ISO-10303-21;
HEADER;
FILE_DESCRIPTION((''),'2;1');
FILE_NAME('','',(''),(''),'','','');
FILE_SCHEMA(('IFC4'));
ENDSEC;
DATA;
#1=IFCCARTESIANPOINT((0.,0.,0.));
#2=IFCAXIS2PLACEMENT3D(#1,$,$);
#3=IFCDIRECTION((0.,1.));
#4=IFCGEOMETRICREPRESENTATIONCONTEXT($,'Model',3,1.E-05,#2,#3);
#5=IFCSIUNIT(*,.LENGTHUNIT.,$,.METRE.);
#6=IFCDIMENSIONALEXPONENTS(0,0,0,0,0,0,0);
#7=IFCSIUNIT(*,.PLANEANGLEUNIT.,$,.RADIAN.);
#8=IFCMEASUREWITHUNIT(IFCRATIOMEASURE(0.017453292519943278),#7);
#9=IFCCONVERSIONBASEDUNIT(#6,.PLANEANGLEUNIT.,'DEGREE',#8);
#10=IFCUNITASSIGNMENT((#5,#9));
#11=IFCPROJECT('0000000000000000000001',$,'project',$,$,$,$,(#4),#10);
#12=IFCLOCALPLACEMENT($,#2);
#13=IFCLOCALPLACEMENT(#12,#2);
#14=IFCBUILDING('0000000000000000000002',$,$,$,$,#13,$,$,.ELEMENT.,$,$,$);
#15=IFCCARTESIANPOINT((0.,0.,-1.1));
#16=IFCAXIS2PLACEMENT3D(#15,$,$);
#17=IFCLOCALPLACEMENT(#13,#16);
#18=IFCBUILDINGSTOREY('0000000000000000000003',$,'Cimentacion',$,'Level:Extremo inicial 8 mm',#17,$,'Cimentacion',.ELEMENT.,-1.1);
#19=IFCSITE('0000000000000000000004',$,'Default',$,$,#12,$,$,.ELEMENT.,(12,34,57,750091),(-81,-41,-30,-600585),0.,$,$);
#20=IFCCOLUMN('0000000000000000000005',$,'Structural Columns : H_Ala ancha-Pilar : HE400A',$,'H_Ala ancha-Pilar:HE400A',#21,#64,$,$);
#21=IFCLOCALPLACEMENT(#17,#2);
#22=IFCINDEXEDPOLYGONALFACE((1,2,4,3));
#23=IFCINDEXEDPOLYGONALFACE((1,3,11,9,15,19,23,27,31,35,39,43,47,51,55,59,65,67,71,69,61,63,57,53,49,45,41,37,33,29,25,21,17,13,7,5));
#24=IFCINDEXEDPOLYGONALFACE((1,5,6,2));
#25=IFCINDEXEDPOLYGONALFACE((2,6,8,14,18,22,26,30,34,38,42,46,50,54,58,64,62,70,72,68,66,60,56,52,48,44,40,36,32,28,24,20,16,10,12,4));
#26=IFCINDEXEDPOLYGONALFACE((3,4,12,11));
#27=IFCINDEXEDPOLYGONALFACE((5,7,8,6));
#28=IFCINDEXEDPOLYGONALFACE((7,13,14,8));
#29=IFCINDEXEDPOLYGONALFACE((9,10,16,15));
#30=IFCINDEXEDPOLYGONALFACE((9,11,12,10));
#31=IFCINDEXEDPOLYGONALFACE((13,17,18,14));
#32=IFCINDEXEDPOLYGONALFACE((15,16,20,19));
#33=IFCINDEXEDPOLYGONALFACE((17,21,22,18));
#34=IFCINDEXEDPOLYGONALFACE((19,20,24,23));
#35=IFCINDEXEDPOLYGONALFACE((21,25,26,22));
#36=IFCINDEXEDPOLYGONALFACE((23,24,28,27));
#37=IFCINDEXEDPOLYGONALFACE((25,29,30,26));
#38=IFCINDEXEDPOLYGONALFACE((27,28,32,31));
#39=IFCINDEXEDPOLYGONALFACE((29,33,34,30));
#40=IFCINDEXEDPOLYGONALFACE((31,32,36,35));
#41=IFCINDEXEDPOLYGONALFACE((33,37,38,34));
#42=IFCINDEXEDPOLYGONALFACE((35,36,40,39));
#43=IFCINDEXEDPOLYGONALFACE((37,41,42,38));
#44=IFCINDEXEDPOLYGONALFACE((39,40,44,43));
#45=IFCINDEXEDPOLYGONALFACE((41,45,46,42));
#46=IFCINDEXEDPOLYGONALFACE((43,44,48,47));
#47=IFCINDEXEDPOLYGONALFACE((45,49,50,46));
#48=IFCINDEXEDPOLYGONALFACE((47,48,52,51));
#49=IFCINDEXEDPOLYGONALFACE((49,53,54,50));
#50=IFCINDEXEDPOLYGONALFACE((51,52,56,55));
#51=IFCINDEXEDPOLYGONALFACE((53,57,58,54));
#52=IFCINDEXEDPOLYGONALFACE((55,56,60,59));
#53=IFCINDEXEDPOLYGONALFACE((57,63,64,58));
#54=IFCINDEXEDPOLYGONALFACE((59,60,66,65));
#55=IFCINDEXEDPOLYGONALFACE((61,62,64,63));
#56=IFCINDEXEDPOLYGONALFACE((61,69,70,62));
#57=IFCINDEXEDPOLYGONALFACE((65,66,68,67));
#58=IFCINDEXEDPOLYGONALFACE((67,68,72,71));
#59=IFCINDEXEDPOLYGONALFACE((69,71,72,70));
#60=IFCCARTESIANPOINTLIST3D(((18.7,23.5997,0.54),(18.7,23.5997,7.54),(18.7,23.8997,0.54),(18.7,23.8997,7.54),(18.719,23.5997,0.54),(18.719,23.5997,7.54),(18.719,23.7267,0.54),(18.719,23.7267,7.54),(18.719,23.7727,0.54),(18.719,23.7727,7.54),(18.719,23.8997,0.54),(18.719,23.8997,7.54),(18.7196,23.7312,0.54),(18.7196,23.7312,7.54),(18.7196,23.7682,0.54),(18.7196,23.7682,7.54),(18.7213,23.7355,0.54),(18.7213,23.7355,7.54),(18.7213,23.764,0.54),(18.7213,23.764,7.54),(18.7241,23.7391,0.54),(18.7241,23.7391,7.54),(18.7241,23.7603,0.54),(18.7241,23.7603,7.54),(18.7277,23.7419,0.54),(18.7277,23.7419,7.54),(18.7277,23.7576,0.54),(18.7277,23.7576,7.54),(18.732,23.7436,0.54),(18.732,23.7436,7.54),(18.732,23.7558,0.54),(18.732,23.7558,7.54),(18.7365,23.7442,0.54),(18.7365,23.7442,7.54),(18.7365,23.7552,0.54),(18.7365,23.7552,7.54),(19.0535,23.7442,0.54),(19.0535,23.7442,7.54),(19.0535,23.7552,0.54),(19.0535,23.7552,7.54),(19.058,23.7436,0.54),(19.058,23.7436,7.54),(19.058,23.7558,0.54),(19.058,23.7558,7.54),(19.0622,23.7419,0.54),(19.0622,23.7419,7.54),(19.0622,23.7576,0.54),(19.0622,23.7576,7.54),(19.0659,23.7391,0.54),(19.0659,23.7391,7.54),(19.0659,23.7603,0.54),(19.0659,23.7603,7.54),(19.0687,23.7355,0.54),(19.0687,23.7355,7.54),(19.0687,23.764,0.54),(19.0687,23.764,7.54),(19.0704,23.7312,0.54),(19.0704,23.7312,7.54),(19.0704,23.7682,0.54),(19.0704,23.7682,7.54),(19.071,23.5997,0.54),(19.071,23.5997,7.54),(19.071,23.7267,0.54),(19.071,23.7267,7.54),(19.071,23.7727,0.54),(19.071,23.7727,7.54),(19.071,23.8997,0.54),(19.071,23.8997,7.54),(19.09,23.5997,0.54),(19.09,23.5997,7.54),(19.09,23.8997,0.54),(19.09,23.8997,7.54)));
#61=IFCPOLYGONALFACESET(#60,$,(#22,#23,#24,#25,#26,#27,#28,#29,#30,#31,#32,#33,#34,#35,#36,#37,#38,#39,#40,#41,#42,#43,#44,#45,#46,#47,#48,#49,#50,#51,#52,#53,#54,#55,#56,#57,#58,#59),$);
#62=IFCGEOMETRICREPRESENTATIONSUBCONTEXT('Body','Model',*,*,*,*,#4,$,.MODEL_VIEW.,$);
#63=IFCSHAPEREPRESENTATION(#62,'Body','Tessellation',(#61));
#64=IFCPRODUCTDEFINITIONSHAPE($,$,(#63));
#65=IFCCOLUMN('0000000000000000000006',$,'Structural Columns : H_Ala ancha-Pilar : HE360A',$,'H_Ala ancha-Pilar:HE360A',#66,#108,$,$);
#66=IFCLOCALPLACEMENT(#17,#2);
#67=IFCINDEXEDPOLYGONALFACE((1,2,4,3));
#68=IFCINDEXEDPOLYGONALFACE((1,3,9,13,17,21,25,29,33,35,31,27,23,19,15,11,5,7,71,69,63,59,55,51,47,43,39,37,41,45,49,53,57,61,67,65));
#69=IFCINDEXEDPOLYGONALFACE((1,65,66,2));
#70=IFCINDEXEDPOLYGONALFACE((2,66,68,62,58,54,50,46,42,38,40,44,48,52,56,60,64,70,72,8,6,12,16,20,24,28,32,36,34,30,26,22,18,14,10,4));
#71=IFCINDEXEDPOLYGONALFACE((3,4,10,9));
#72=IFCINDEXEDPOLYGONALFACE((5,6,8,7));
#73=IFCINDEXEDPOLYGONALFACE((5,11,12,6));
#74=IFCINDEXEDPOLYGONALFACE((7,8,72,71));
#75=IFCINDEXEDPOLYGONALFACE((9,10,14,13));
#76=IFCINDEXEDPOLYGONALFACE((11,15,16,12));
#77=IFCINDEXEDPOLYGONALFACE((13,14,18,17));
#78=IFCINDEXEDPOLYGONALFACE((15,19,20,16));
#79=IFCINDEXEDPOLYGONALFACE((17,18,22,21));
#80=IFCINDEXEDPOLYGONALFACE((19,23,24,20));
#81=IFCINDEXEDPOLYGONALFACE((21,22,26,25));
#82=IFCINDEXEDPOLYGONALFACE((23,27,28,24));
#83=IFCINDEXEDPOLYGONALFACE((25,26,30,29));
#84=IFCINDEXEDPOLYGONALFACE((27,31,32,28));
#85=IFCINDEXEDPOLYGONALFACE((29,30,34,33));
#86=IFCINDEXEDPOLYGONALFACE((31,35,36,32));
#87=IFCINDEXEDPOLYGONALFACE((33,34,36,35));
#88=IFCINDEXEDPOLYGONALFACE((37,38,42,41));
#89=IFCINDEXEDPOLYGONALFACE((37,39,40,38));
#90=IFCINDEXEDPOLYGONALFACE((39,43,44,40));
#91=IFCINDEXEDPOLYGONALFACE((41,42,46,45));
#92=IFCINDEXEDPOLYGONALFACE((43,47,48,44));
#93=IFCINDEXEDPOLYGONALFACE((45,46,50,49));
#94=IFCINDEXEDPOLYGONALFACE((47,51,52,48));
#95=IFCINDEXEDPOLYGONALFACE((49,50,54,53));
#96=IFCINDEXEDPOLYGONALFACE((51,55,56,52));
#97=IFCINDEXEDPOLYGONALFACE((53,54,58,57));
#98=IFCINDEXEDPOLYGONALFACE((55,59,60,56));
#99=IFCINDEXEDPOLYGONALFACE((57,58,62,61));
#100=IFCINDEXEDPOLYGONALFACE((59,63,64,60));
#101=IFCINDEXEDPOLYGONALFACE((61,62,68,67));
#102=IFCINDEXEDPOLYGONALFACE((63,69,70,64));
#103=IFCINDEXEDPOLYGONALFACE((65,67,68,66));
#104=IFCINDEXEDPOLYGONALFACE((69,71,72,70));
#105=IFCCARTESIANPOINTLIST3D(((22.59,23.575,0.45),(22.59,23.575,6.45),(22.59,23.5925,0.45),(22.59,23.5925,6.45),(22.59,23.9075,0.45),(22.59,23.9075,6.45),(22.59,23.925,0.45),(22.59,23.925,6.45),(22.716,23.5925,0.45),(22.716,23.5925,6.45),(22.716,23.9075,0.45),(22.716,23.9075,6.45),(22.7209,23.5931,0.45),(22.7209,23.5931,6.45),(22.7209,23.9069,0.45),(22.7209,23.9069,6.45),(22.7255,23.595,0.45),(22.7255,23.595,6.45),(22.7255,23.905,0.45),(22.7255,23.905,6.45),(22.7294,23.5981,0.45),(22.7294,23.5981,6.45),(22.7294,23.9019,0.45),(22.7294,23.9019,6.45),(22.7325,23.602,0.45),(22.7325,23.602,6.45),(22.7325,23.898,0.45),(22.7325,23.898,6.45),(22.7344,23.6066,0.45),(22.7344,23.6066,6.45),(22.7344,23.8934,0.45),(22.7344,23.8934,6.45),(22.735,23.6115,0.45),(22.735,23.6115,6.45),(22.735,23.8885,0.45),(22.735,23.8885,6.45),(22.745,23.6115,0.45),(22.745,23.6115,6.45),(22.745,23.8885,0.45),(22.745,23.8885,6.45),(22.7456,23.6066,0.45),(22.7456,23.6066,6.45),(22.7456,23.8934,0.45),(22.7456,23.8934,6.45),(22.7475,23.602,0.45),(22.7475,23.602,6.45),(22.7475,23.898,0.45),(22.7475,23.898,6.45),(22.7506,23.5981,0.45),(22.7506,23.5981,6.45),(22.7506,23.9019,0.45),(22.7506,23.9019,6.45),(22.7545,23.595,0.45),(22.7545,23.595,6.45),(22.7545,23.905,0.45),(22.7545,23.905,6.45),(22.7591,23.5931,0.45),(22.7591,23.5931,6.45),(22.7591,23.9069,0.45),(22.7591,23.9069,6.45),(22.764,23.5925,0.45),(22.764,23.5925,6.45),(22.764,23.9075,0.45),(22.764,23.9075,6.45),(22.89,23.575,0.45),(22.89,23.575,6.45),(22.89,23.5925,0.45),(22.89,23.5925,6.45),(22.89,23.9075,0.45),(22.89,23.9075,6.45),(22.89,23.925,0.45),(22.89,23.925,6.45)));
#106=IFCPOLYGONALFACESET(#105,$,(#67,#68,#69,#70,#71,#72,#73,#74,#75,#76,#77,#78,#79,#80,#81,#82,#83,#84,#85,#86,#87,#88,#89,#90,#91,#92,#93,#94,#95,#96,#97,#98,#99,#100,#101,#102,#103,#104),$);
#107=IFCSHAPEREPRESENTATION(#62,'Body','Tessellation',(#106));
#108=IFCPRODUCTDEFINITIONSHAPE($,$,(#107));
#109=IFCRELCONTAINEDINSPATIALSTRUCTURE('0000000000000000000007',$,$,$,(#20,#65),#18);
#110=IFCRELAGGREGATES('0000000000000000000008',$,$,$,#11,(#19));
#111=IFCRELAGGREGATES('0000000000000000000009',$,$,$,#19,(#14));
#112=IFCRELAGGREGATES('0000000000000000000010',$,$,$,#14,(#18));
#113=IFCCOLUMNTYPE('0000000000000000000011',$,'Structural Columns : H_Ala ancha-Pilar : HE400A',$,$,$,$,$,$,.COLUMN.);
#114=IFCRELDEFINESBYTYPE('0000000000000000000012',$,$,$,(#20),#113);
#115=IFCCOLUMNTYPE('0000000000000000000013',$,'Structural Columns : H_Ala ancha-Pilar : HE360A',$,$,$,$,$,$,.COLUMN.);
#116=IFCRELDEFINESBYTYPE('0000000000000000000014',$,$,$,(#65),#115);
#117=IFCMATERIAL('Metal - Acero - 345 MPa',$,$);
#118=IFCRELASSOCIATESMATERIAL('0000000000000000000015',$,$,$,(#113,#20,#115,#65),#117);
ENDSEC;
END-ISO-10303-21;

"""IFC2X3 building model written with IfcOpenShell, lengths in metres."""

from ifc_helpers import new_model, entity, si_unit, converted_unit, direction, frame, frame_2d, origin, place, context, subcontext, project, spatial, polyline, circle_curve, parameter, trimmed, segment, composite_curve, outline, extrude, source, transform, mapped, material, type_object, type_shapes, element, save


model = new_model("IFC2X3")

# Units and contexts
model_context = context("Model", 3, precision=1e-05, world=origin(), true_north=direction((0.0, 1.0)))
body_context = subcontext(model_context, "Body", "Model", "MODEL_VIEW")
ifc_project = project(units=[si_unit("LENGTHUNIT", "METRE"), converted_unit("PLANEANGLEUNIT", "DEGREE", entity("IfcRatioMeasure", 0.017453292519943278), si_unit("PLANEANGLEUNIT", "RADIAN"), dimensions=[0, 0, 0, 0, 0, 0, 0])], contexts=[model_context])

# Site, building, storey
site_placement = place(None, origin())
site = spatial("IfcSite", under=ifc_project, at=site_placement, Name="Default", CompositionType="ELEMENT", RefLatitude=(12, 34, 57, 750091), RefLongitude=(-81, -41, -30, -600585), RefElevation=0.0)
building_placement = place(site_placement, origin())
building = spatial("IfcBuilding", under=site, at=building_placement, CompositionType="ELEMENT")
storey_placement = place(building_placement, frame((0.0, 0.0, -1.1)))
storey = spatial("IfcBuildingStorey", under=building, at=storey_placement, Name="Cimentacion", ObjectType="Level:Extremo inicial 8 mm", LongName="Cimentacion", CompositionType="ELEMENT", Elevation=-1.1)

# Columns
ifc_material = material(Name="Metal - Acero - 345 MPa")
column_type_1 = type_object("IfcColumnType", Name="Structural Columns : H_Ala ancha-Pilar : HE400A", PredefinedType="COLUMN", material=ifc_material)
shared_shape_1 = source(origin(), body_context, "Body", "SweptSolid", [
    extrude(outline(composite_curve([segment(polyline([(0.176, -0.15), (0.195, -0.15)]), True, "CONTINUOUS"), segment(polyline([(0.195, -0.15), (0.195, 0.15)]), True, "CONTINUOUS"), segment(polyline([(0.195, 0.15), (0.176, 0.15)]), True, "CONTINUOUS"), segment(polyline([(0.176, 0.15), (0.176, 0.023)]), True, "CONTINUOUS"), segment(trimmed(circle_curve(frame_2d((0.1585, 0.023), x_axis=(1.0, 0.0)), 0.0175), [parameter(270.0)], [parameter(0.0)], True, "PARAMETER"), False, "CONTINUOUS"), segment(polyline([(0.1585, 0.0055), (-0.1585, 0.0055)]), True, "CONTINUOUS"), segment(trimmed(circle_curve(frame_2d((-0.1585, 0.023), x_axis=(0.0, -1.0)), 0.0175), [parameter(270.0)], [parameter(0.0)], True, "PARAMETER"), False, "CONTINUOUS"), segment(polyline([(-0.176, 0.023), (-0.176, 0.15)]), True, "CONTINUOUS"), segment(polyline([(-0.176, 0.15), (-0.195, 0.15)]), True, "CONTINUOUS"), segment(polyline([(-0.195, 0.15), (-0.195, -0.15)]), True, "CONTINUOUS"), segment(polyline([(-0.195, -0.15), (-0.176, -0.15)]), True, "CONTINUOUS"), segment(polyline([(-0.176, -0.15), (-0.176, -0.023)]), True, "CONTINUOUS"), segment(trimmed(circle_curve(frame_2d((-0.1585, -0.023), x_axis=(-1.0, 0.0)), 0.0175), [parameter(270.0)], [parameter(0.0)], True, "PARAMETER"), False, "CONTINUOUS"), segment(polyline([(-0.1585, -0.0055), (0.1585, -0.0055)]), True, "CONTINUOUS"), segment(trimmed(circle_curve(frame_2d((0.1585, -0.023), x_axis=(0.0, 1.0)), 0.0175), [parameter(270.0)], [parameter(0.0)], True, "PARAMETER"), False, "CONTINUOUS"), segment(polyline([(0.176, -0.023), (0.176, -0.15)]), True, "CONTINUOUS")], self_intersect=False)), frame((0.0, 0.0, -0.56), z_axis=(0.0, 0.0, 1.0), x_axis=(0.0, -1.0, 0.0)), (0.0, 0.0, 1.0), 7.0),
])
type_shapes(column_type_1, [shared_shape_1])
for number, where, z_axis, x_axis, name in (
    (1, (18.895, 23.7497, 1.1), (0.0, 0.0, 1.0), (0.0, 1.0, 0.0), "Structural Columns : H_Ala ancha-Pilar : HE400A"),
):
    element("IfcColumn", number, at=place(storey_placement, frame(where, z_axis=z_axis, x_axis=x_axis)), inside=storey, type_object=column_type_1, material=ifc_material, Name=name, ObjectType="H_Ala ancha-Pilar:HE400A", context=body_context, shape_type="MappedRepresentation", body=[
        mapped(shared_shape_1, transform((0.0, 0.0, 0.0), scale=1.0)),
    ])
column_type_2 = type_object("IfcColumnType", Name="Structural Columns : H_Ala ancha-Pilar : HE360A", PredefinedType="COLUMN", material=ifc_material)
shared_shape_2 = source(origin(), body_context, "Body", "SweptSolid", [
    extrude(outline(composite_curve([segment(polyline([(0.1575, -0.15), (0.175, -0.15)]), True, "CONTINUOUS"), segment(polyline([(0.175, -0.15), (0.175, 0.15)]), True, "CONTINUOUS"), segment(polyline([(0.175, 0.15), (0.1575, 0.15)]), True, "CONTINUOUS"), segment(polyline([(0.1575, 0.15), (0.1575, 0.024)]), True, "CONTINUOUS"), segment(trimmed(circle_curve(frame_2d((0.1385, 0.024), x_axis=(1.0, 0.0)), 0.019), [parameter(270.0)], [parameter(0.0)], True, "PARAMETER"), False, "CONTINUOUS"), segment(polyline([(0.1385, 0.005), (-0.1385, 0.005)]), True, "CONTINUOUS"), segment(trimmed(circle_curve(frame_2d((-0.1385, 0.024), x_axis=(0.0, -1.0)), 0.019), [parameter(270.0)], [parameter(0.0)], True, "PARAMETER"), False, "CONTINUOUS"), segment(polyline([(-0.1575, 0.024), (-0.1575, 0.15)]), True, "CONTINUOUS"), segment(polyline([(-0.1575, 0.15), (-0.175, 0.15)]), True, "CONTINUOUS"), segment(polyline([(-0.175, 0.15), (-0.175, -0.15)]), True, "CONTINUOUS"), segment(polyline([(-0.175, -0.15), (-0.1575, -0.15)]), True, "CONTINUOUS"), segment(polyline([(-0.1575, -0.15), (-0.1575, -0.024)]), True, "CONTINUOUS"), segment(trimmed(circle_curve(frame_2d((-0.1385, -0.024), x_axis=(-1.0, 0.0)), 0.019), [parameter(270.0)], [parameter(0.0)], True, "PARAMETER"), False, "CONTINUOUS"), segment(polyline([(-0.1385, -0.005), (0.1385, -0.005)]), True, "CONTINUOUS"), segment(trimmed(circle_curve(frame_2d((0.1385, -0.024), x_axis=(0.0, 1.0)), 0.019), [parameter(270.0)], [parameter(0.0)], True, "PARAMETER"), False, "CONTINUOUS"), segment(polyline([(0.1575, -0.024), (0.1575, -0.15)]), True, "CONTINUOUS")], self_intersect=False)), frame((0.0, 0.0, -0.65), z_axis=(0.0, 0.0, 1.0), x_axis=(0.0, -1.0, 0.0)), (0.0, 0.0, 1.0), 6.0),
])
type_shapes(column_type_2, [shared_shape_2])
column_1_placement = place(storey_placement, frame((22.74, 23.75, 1.1)))
element("IfcColumn", 2, at=column_1_placement, inside=storey, type_object=column_type_2, material=ifc_material, Name="Structural Columns : H_Ala ancha-Pilar : HE360A", ObjectType="H_Ala ancha-Pilar:HE360A", context=body_context, shape_type="MappedRepresentation", body=[
    mapped(shared_shape_2, transform((0.0, 0.0, 0.0), scale=1.0)),
])

save(model, "model.ifc")
